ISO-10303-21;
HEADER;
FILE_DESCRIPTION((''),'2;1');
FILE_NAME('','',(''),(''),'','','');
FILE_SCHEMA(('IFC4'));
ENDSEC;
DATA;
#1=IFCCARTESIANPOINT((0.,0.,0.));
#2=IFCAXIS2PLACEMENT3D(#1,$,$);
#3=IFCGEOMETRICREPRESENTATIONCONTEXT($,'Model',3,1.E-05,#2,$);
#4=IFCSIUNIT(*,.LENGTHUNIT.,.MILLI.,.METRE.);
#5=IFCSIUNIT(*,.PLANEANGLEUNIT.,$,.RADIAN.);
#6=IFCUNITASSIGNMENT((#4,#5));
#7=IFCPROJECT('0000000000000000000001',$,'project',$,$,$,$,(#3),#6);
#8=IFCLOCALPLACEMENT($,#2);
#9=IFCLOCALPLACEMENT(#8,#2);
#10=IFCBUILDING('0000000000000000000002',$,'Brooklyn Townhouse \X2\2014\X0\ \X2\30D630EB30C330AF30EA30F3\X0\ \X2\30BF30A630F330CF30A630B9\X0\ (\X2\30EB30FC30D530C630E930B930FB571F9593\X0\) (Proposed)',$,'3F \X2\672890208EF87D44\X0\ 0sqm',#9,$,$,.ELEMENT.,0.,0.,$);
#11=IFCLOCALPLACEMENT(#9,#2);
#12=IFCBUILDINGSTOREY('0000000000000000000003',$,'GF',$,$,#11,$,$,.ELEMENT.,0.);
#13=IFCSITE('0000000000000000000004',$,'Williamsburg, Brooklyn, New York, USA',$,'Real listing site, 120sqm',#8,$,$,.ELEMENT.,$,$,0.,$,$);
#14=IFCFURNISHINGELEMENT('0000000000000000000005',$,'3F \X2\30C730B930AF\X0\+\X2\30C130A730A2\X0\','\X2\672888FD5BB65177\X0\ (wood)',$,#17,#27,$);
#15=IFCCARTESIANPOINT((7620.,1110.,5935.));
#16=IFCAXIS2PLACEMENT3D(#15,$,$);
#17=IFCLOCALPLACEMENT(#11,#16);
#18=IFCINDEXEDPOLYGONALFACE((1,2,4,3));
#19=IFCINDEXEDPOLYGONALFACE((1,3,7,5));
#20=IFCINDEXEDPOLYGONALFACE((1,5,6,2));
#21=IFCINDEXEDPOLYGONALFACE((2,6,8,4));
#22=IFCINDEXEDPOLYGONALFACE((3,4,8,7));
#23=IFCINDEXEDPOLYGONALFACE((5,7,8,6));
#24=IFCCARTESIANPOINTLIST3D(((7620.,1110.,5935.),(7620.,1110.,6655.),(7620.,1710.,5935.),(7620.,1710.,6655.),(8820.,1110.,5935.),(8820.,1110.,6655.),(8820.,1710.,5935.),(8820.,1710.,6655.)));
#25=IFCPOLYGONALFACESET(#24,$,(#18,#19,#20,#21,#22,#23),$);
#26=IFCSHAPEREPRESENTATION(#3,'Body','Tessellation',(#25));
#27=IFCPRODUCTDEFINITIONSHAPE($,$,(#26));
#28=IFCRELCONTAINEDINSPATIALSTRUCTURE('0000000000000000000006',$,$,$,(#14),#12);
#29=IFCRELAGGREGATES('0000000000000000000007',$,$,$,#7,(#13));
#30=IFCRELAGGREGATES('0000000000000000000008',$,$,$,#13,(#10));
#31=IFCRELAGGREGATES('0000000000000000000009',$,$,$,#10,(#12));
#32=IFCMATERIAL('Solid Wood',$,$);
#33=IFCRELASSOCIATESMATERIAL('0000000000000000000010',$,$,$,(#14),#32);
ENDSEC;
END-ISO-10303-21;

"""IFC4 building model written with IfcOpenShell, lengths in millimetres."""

from ifc_helpers import new_model, si_unit, frame, frame_2d, origin, place, context, project, spatial, rectangle, extrude, material, element, save


model = new_model("IFC4")

# Units and contexts
model_context = context("Model", 3, precision=1e-05, world=origin())
ifc_project = project(units=[si_unit("LENGTHUNIT", "METRE", prefix="MILLI"), si_unit("PLANEANGLEUNIT", "RADIAN")], contexts=[model_context])

# Site, building, storey
site_placement = place(None, origin())
site = spatial("IfcSite", under=ifc_project, at=site_placement, Name="Williamsburg, Brooklyn, New York, USA", ObjectType="Real listing site, 120sqm", CompositionType="ELEMENT", RefElevation=0.0)
building_placement = place(site_placement, origin())
building = spatial("IfcBuilding", under=site, at=building_placement, Name="Brooklyn Townhouse — ブルックリン タウンハウス (ルーフテラス・土間) (Proposed)", ObjectType="3F 木造軸組 0sqm", CompositionType="ELEMENT", ElevationOfRefHeight=0.0, ElevationOfTerrain=0.0)
storey_placement = place(building_placement, origin())
storey = spatial("IfcBuildingStorey", under=building, at=storey_placement, Name="GF", CompositionType="ELEMENT", Elevation=0.0)

# Shared definitions
ifc_material_1 = material(Name="Solid Wood")

# Furnishing element
furnishing_1_placement = place(storey_placement, frame((7620.0, 1110.0, 5935.0)))
element("IfcFurnishingElement", 1, at=furnishing_1_placement, inside=storey, material=ifc_material_1, Name="3F デスク+チェア", Description="木製家具 (wood)", context=model_context, shape_type="SweptSolid", body=[
    extrude(rectangle(XDim=1200.0, YDim=600.0, at=frame_2d((600.0, 300.0))), frame((7620.0, 1110.0, 5935.0)), (0.0, 0.0, 1.0), 720.0),
])

save(model, "model.ifc")
